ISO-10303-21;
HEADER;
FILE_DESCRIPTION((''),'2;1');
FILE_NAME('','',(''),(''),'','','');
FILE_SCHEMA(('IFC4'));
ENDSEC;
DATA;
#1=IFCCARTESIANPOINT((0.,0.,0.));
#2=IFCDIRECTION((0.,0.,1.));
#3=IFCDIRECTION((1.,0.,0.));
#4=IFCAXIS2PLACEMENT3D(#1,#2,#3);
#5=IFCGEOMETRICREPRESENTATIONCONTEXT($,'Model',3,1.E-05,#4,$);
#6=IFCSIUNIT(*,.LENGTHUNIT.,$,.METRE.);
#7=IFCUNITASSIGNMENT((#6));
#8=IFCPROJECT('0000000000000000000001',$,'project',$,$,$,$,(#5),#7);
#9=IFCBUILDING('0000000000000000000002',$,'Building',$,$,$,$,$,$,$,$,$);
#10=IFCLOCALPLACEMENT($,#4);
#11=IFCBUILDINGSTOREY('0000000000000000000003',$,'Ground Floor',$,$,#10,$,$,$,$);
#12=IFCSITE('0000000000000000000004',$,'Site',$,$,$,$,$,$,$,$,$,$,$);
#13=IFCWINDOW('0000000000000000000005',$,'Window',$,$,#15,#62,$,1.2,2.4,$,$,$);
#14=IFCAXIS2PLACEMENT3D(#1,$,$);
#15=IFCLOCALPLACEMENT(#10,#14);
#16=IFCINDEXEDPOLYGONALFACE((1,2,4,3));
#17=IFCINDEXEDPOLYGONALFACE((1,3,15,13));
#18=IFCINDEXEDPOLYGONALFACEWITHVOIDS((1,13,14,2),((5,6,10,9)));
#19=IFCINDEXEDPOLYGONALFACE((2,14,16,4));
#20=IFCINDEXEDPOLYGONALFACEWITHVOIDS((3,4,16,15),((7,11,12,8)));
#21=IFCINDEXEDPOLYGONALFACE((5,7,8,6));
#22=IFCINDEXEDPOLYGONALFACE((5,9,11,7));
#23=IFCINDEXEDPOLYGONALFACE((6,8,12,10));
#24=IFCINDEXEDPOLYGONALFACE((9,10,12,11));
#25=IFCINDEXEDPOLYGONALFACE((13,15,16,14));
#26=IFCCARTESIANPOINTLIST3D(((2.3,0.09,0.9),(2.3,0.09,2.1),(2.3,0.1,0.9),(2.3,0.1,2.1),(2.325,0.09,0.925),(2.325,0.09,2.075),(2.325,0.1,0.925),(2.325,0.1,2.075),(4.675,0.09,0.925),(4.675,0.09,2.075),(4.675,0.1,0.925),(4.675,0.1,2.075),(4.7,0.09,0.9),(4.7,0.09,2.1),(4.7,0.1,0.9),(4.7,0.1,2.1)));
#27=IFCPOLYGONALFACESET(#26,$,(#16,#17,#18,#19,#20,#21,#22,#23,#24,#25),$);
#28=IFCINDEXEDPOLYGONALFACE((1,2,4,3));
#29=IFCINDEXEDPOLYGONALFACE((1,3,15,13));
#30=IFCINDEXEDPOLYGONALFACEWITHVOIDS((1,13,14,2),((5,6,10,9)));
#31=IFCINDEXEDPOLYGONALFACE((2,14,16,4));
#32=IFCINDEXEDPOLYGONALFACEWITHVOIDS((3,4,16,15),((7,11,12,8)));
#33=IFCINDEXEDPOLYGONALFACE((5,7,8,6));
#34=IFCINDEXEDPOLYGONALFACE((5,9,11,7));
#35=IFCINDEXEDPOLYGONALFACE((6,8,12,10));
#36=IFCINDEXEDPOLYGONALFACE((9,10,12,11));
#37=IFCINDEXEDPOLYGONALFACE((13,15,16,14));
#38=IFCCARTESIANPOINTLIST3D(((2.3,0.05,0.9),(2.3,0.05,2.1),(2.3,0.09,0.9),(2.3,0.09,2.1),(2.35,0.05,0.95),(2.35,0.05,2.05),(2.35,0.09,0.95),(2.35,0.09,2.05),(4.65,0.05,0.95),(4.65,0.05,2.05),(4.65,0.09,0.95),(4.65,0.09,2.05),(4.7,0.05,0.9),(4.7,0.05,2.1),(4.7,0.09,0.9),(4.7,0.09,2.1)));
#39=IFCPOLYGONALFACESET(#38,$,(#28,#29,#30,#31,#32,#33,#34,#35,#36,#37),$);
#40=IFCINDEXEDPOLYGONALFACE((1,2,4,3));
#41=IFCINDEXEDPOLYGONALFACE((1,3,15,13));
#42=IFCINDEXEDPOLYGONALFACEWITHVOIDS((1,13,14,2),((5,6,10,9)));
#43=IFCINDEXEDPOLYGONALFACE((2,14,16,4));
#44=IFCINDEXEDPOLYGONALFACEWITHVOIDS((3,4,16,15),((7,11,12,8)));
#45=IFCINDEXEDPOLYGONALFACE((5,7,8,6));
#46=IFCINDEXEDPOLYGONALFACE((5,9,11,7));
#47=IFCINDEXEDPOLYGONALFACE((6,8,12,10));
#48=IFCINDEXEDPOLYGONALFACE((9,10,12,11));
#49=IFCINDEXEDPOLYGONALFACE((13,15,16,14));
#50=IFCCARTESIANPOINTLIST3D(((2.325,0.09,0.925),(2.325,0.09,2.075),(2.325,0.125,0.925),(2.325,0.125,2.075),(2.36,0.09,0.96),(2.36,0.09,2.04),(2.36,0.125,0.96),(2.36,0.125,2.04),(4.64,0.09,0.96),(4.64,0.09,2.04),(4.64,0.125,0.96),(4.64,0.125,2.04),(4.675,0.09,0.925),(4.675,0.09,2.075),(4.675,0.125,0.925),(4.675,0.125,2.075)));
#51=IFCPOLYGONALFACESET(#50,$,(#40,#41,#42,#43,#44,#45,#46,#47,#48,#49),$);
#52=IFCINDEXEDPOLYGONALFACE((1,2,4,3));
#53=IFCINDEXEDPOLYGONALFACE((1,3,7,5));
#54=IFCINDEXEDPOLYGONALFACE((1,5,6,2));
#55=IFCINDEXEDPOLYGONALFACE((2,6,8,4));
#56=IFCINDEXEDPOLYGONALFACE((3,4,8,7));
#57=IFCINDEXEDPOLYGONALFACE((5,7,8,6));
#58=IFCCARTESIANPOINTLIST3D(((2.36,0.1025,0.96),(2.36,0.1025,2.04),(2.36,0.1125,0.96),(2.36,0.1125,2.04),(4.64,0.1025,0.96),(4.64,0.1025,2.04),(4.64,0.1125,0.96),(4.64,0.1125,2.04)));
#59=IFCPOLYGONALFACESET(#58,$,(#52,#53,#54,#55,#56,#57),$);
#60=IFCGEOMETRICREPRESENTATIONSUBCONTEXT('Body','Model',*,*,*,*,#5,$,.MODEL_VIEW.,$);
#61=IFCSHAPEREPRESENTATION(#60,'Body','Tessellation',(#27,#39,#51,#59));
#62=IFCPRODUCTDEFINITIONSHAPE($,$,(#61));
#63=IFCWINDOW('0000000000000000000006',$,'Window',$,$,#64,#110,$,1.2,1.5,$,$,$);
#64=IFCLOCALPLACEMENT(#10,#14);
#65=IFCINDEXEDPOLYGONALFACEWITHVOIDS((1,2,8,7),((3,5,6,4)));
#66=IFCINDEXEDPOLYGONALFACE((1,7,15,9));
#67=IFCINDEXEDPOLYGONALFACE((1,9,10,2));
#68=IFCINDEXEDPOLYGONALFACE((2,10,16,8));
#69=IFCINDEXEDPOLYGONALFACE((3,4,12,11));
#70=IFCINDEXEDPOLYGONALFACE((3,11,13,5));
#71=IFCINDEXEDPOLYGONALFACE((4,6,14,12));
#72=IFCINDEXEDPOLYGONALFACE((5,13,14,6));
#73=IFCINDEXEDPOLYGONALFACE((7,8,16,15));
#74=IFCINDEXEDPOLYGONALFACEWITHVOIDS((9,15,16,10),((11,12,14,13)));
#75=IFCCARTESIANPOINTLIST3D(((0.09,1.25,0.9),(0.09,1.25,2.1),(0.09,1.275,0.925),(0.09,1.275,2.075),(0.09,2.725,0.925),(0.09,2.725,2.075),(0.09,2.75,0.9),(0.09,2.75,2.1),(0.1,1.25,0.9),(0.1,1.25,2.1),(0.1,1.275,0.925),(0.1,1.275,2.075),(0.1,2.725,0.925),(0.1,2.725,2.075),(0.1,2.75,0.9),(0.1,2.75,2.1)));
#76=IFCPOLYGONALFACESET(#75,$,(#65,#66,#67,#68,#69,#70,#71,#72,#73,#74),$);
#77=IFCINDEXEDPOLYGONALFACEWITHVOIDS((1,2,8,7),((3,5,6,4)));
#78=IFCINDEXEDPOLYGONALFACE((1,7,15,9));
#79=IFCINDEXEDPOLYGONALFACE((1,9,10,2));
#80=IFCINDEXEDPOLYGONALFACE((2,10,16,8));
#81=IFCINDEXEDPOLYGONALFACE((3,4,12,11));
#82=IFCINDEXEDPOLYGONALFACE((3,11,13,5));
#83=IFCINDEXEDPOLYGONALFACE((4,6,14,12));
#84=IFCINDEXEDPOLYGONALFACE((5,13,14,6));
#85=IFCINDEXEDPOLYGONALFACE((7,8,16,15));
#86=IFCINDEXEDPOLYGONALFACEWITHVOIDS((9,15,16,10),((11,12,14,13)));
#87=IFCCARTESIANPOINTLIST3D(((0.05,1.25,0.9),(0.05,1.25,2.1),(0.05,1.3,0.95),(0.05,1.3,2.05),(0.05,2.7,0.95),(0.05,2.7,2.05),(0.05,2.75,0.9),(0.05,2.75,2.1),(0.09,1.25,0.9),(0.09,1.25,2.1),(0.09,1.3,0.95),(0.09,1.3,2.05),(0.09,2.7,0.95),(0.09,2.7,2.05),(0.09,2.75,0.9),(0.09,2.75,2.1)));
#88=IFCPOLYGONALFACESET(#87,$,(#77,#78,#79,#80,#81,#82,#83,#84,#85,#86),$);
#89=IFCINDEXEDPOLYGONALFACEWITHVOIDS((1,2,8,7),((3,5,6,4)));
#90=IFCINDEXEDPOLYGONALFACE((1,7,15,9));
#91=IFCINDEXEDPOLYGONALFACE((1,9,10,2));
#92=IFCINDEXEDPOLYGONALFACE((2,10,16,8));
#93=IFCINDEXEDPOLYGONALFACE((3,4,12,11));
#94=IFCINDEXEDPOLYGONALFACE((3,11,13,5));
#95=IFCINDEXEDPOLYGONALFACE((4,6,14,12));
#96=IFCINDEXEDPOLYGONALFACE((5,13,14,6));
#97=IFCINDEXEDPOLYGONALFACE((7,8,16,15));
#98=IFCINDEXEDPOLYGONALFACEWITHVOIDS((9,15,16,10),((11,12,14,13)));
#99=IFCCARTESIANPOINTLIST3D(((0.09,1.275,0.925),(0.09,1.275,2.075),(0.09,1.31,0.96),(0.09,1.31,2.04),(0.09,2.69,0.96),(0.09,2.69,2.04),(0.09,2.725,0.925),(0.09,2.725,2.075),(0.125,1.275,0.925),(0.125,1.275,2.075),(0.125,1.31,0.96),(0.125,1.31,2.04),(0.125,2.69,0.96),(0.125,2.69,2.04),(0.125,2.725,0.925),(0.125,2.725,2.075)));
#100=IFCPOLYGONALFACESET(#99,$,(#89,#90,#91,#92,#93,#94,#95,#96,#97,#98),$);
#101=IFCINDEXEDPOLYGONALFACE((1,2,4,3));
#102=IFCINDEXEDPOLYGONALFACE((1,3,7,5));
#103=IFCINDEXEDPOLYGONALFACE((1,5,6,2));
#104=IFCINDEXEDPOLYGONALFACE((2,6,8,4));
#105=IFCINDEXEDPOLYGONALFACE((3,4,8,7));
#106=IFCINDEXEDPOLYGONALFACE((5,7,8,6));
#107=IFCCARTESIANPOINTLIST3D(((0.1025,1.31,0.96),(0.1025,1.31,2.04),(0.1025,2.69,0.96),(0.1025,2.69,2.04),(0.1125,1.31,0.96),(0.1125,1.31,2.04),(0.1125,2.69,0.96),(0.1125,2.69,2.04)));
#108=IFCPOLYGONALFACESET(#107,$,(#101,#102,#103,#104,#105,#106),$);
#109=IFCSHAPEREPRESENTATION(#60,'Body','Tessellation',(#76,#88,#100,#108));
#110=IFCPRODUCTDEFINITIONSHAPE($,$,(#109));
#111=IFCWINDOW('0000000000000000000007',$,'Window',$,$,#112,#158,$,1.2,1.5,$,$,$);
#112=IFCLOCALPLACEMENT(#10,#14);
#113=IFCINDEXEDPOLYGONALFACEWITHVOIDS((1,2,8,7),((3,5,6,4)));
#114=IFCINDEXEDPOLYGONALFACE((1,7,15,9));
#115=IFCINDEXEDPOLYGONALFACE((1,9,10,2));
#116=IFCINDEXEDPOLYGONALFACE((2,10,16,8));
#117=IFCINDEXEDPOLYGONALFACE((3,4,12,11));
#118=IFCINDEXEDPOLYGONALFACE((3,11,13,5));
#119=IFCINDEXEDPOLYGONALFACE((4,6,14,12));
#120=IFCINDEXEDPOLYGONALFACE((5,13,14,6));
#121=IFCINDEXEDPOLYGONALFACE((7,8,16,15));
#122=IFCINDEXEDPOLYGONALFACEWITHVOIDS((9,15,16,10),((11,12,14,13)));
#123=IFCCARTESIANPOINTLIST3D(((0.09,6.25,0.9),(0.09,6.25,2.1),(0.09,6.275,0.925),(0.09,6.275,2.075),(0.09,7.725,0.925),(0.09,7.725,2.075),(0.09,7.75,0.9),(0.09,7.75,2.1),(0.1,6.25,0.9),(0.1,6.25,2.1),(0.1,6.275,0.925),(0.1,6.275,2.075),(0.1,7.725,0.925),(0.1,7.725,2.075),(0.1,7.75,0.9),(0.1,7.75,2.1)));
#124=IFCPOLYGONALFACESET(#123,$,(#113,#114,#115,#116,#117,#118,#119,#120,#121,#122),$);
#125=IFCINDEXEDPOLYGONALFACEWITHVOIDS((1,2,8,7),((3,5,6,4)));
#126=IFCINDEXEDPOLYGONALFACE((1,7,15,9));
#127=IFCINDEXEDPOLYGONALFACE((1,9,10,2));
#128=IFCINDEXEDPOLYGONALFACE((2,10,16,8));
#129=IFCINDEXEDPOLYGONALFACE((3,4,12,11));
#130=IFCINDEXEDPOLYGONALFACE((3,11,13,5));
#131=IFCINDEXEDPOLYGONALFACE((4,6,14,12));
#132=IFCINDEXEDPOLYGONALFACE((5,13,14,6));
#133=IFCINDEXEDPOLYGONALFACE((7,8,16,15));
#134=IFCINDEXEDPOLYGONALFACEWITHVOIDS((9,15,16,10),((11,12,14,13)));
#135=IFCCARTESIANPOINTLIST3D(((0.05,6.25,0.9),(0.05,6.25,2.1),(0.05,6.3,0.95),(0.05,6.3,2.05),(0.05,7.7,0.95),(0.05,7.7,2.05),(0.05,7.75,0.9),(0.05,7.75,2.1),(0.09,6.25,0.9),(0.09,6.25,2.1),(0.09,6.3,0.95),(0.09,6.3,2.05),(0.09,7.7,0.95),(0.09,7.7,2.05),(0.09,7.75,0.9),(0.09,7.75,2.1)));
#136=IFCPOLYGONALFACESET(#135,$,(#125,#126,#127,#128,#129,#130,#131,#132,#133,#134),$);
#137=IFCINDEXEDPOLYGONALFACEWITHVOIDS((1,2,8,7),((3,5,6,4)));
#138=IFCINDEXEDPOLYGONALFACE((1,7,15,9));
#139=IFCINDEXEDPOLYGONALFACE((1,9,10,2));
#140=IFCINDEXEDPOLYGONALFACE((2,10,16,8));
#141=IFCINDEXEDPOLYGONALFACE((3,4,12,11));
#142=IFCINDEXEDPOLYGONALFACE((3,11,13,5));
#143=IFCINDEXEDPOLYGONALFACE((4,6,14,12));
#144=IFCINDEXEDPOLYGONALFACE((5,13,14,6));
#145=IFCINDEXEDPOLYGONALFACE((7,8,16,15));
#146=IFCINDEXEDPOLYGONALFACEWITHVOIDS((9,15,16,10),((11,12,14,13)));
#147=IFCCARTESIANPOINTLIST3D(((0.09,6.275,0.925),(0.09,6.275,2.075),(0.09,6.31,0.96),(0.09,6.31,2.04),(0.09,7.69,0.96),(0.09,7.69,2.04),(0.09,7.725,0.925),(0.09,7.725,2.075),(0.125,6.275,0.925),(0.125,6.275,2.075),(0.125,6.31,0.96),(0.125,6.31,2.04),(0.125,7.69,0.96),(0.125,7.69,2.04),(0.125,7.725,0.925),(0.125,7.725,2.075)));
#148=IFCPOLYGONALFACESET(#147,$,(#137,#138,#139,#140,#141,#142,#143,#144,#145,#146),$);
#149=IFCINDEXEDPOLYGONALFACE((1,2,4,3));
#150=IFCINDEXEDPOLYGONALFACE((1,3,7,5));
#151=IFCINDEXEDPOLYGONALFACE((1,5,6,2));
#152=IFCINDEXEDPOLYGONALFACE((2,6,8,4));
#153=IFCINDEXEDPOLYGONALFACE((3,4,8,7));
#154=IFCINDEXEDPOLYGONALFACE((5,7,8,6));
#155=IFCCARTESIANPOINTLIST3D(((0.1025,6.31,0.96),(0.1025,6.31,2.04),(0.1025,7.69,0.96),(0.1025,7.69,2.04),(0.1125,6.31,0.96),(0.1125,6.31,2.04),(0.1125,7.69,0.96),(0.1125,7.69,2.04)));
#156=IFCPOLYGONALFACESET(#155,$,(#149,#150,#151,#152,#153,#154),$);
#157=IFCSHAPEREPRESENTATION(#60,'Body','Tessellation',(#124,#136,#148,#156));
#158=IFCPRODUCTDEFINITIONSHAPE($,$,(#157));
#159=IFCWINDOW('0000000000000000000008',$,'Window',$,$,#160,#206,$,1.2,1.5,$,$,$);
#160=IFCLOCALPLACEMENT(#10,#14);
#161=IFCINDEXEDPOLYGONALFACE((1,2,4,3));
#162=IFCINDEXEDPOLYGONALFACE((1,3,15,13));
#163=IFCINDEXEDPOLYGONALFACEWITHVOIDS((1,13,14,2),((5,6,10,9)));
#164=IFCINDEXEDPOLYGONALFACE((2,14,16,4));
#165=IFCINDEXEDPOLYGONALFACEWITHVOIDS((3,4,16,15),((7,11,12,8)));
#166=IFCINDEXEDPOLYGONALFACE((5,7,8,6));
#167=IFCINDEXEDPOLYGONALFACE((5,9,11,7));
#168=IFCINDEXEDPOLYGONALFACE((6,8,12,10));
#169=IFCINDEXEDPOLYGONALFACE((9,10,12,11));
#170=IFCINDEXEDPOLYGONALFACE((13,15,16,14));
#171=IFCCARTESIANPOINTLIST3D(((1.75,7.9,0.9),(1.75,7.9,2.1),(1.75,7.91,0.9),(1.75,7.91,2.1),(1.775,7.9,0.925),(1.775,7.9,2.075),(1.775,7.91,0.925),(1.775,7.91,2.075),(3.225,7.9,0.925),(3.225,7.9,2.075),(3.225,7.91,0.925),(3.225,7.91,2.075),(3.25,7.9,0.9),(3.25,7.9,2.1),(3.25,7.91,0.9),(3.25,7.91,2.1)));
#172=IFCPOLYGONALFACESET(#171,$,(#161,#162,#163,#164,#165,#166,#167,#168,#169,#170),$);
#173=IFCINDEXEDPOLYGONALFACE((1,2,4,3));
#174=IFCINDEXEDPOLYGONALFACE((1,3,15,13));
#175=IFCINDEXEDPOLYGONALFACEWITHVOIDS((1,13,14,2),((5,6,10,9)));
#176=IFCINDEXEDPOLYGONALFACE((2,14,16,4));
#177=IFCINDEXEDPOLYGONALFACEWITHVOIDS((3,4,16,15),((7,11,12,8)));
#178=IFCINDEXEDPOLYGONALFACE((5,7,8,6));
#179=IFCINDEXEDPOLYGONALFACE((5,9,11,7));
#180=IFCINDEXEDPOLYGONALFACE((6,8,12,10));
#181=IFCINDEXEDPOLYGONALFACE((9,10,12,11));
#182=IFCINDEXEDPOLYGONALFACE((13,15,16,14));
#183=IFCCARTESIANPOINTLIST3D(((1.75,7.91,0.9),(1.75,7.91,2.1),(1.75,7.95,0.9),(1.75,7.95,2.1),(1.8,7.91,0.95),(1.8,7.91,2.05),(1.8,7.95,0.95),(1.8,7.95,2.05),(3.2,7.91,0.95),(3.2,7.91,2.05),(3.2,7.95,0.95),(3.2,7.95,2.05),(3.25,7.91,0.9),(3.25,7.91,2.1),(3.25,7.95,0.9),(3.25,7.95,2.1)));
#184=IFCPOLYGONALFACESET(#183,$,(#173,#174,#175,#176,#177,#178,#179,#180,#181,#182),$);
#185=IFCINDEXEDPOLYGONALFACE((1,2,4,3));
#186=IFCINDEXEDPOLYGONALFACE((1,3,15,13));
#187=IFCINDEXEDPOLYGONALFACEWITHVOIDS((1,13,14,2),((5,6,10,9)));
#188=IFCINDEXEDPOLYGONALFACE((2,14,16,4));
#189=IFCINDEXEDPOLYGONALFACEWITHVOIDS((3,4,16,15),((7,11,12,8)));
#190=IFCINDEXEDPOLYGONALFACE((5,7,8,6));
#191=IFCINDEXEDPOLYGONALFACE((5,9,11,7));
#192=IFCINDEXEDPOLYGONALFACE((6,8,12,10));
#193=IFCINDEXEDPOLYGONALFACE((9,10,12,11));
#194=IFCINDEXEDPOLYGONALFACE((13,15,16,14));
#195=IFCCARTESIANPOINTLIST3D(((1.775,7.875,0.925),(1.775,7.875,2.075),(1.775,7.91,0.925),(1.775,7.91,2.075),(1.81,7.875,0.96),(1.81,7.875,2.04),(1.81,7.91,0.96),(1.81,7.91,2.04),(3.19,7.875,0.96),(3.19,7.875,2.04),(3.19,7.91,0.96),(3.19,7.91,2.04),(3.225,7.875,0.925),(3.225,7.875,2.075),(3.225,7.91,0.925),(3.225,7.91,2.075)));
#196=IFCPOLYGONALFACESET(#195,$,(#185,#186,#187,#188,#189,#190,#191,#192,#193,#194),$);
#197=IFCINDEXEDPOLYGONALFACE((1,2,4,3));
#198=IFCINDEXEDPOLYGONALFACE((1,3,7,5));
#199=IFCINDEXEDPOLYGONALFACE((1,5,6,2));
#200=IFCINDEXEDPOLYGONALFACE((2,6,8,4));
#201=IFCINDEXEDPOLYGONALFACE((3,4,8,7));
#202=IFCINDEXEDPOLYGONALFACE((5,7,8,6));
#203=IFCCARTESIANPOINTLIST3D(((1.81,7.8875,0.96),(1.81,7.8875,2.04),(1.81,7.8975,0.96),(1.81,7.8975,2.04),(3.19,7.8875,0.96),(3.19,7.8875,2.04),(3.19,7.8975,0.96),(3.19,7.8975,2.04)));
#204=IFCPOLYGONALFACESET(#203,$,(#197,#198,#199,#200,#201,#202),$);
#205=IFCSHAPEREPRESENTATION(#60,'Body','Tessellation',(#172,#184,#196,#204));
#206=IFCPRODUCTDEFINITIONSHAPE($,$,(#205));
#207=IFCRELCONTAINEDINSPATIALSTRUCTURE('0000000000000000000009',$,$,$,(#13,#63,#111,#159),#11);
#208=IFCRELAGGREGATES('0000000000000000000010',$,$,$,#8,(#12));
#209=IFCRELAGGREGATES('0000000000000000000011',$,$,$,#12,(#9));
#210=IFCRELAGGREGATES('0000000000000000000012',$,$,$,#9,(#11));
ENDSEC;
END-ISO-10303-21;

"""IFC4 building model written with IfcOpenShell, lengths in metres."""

from ifc_helpers import new_model, si_unit, frame, origin_with_axes, place, context, subcontext, project, spatial, line, indexed_curve, outline, extrude, element, save


model = new_model("IFC4")

# Units and contexts
model_context = context("Model", 3, precision=1e-05, world=origin_with_axes())
body_context = subcontext(model_context, "Body", "Model", "MODEL_VIEW")
ifc_project = project(units=[si_unit("LENGTHUNIT", "METRE")], contexts=[model_context])

# Site, building, storey
site = spatial("IfcSite", under=ifc_project, Name="Site")
building = spatial("IfcBuilding", under=site, Name="Building")
storey_placement = place(None, origin_with_axes())
storey = spatial("IfcBuildingStorey", under=building, at=storey_placement, Name="Ground Floor")

# Windows
window_placement = place(storey_placement, frame((2.3, 0.0, 0.9), z_axis=(0.0, 0.0, 1.0), x_axis=(1.0, 0.0, 0.0)))
element("IfcWindow", 1, at=window_placement, inside=storey, Name="Window", OverallHeight=1.2, OverallWidth=2.4, context=body_context, shape_type="SweptSolid", body=[
    extrude(outline(indexed_curve([(0.0, 0.0), (2.4, 0.0), (2.4, 1.2), (0.0, 1.2)], segments=[line(1, 2, 3, 4, 1)]), holes=[indexed_curve([(0.025, 0.025), (2.375, 0.025), (2.375, 1.175), (0.025, 1.175)], segments=[line(1, 2, 3, 4, 1)])]), frame((0.0, 0.09, 0.0), z_axis=(0.0, -1.0, 0.0), x_axis=(1.0, 0.0, 0.0)), (0.0, 0.0, -1.0), 0.01),
    extrude(outline(indexed_curve([(0.0, 0.0), (2.4, 0.0), (2.4, 1.2), (0.0, 1.2)], segments=[line(1, 2, 3, 4, 1)]), holes=[indexed_curve([(0.05, 0.05), (2.35, 0.05), (2.35, 1.15), (0.05, 1.15)], segments=[line(1, 2, 3, 4, 1)])]), frame((0.0, 0.05, 0.0), z_axis=(0.0, -1.0, 0.0), x_axis=(1.0, 0.0, 0.0)), (0.0, 0.0, -1.0), 0.04),
    extrude(outline(indexed_curve([(0.0, 0.0), (2.35, 0.0), (2.35, 1.15), (0.0, 1.15)], segments=[line(1, 2, 3, 4, 1)]), holes=[indexed_curve([(0.035, 0.035), (2.315, 0.035), (2.315, 1.115), (0.035, 1.115)], segments=[line(1, 2, 3, 4, 1)])]), frame((0.025, 0.09, 0.025), z_axis=(0.0, -1.0, 0.0), x_axis=(1.0, 0.0, 0.0)), (0.0, 0.0, -1.0), 0.035),
    extrude(outline(indexed_curve([(0.035, 0.035), (2.315, 0.035), (2.315, 1.115), (0.035, 1.115)], segments=[line(1, 2, 3, 4, 1)])), frame((0.025, 0.1025, 0.025), z_axis=(0.0, -1.0, 0.0), x_axis=(1.0, 0.0, 0.0)), (0.0, 0.0, -1.0), 0.01),
])
for number, where, z_axis, x_axis, name in (
    (2, (0.0, 2.75, 0.9), (0.0, 0.0, 1.0), (0.0, -1.0, 0.0), "Window"),
    (3, (0.0, 7.75, 0.9), (0.0, 0.0, 1.0), (0.0, -1.0, 0.0), "Window"),
    (4, (3.25, 8.0, 0.9), (0.0, 0.0, 1.0), (-1.0, 0.0, 0.0), "Window"),
):
    element("IfcWindow", number, at=place(storey_placement, frame(where, z_axis=z_axis, x_axis=x_axis)), inside=storey, Name=name, OverallHeight=1.2, OverallWidth=1.5, context=body_context, shape_type="SweptSolid", body=[
        extrude(outline(indexed_curve([(0.0, 0.0), (1.5, 0.0), (1.5, 1.2), (0.0, 1.2)], segments=[line(1, 2, 3, 4, 1)]), holes=[indexed_curve([(0.025, 0.025), (1.475, 0.025), (1.475, 1.175), (0.025, 1.175)], segments=[line(1, 2, 3, 4, 1)])]), frame((0.0, 0.09, 0.0), z_axis=(0.0, -1.0, 0.0), x_axis=(1.0, 0.0, 0.0)), (0.0, 0.0, -1.0), 0.01),
        extrude(outline(indexed_curve([(0.0, 0.0), (1.5, 0.0), (1.5, 1.2), (0.0, 1.2)], segments=[line(1, 2, 3, 4, 1)]), holes=[indexed_curve([(0.05, 0.05), (1.45, 0.05), (1.45, 1.15), (0.05, 1.15)], segments=[line(1, 2, 3, 4, 1)])]), frame((0.0, 0.05, 0.0), z_axis=(0.0, -1.0, 0.0), x_axis=(1.0, 0.0, 0.0)), (0.0, 0.0, -1.0), 0.04),
        extrude(outline(indexed_curve([(0.0, 0.0), (1.45, 0.0), (1.45, 1.15), (0.0, 1.15)], segments=[line(1, 2, 3, 4, 1)]), holes=[indexed_curve([(0.035, 0.035), (1.415, 0.035), (1.415, 1.115), (0.035, 1.115)], segments=[line(1, 2, 3, 4, 1)])]), frame((0.025, 0.09, 0.025), z_axis=(0.0, -1.0, 0.0), x_axis=(1.0, 0.0, 0.0)), (0.0, 0.0, -1.0), 0.035),
        extrude(outline(indexed_curve([(0.035, 0.035), (1.415, 0.035), (1.415, 1.115), (0.035, 1.115)], segments=[line(1, 2, 3, 4, 1)])), frame((0.025, 0.1025, 0.025), z_axis=(0.0, -1.0, 0.0), x_axis=(1.0, 0.0, 0.0)), (0.0, 0.0, -1.0), 0.01),
    ])

save(model, "model.ifc")
